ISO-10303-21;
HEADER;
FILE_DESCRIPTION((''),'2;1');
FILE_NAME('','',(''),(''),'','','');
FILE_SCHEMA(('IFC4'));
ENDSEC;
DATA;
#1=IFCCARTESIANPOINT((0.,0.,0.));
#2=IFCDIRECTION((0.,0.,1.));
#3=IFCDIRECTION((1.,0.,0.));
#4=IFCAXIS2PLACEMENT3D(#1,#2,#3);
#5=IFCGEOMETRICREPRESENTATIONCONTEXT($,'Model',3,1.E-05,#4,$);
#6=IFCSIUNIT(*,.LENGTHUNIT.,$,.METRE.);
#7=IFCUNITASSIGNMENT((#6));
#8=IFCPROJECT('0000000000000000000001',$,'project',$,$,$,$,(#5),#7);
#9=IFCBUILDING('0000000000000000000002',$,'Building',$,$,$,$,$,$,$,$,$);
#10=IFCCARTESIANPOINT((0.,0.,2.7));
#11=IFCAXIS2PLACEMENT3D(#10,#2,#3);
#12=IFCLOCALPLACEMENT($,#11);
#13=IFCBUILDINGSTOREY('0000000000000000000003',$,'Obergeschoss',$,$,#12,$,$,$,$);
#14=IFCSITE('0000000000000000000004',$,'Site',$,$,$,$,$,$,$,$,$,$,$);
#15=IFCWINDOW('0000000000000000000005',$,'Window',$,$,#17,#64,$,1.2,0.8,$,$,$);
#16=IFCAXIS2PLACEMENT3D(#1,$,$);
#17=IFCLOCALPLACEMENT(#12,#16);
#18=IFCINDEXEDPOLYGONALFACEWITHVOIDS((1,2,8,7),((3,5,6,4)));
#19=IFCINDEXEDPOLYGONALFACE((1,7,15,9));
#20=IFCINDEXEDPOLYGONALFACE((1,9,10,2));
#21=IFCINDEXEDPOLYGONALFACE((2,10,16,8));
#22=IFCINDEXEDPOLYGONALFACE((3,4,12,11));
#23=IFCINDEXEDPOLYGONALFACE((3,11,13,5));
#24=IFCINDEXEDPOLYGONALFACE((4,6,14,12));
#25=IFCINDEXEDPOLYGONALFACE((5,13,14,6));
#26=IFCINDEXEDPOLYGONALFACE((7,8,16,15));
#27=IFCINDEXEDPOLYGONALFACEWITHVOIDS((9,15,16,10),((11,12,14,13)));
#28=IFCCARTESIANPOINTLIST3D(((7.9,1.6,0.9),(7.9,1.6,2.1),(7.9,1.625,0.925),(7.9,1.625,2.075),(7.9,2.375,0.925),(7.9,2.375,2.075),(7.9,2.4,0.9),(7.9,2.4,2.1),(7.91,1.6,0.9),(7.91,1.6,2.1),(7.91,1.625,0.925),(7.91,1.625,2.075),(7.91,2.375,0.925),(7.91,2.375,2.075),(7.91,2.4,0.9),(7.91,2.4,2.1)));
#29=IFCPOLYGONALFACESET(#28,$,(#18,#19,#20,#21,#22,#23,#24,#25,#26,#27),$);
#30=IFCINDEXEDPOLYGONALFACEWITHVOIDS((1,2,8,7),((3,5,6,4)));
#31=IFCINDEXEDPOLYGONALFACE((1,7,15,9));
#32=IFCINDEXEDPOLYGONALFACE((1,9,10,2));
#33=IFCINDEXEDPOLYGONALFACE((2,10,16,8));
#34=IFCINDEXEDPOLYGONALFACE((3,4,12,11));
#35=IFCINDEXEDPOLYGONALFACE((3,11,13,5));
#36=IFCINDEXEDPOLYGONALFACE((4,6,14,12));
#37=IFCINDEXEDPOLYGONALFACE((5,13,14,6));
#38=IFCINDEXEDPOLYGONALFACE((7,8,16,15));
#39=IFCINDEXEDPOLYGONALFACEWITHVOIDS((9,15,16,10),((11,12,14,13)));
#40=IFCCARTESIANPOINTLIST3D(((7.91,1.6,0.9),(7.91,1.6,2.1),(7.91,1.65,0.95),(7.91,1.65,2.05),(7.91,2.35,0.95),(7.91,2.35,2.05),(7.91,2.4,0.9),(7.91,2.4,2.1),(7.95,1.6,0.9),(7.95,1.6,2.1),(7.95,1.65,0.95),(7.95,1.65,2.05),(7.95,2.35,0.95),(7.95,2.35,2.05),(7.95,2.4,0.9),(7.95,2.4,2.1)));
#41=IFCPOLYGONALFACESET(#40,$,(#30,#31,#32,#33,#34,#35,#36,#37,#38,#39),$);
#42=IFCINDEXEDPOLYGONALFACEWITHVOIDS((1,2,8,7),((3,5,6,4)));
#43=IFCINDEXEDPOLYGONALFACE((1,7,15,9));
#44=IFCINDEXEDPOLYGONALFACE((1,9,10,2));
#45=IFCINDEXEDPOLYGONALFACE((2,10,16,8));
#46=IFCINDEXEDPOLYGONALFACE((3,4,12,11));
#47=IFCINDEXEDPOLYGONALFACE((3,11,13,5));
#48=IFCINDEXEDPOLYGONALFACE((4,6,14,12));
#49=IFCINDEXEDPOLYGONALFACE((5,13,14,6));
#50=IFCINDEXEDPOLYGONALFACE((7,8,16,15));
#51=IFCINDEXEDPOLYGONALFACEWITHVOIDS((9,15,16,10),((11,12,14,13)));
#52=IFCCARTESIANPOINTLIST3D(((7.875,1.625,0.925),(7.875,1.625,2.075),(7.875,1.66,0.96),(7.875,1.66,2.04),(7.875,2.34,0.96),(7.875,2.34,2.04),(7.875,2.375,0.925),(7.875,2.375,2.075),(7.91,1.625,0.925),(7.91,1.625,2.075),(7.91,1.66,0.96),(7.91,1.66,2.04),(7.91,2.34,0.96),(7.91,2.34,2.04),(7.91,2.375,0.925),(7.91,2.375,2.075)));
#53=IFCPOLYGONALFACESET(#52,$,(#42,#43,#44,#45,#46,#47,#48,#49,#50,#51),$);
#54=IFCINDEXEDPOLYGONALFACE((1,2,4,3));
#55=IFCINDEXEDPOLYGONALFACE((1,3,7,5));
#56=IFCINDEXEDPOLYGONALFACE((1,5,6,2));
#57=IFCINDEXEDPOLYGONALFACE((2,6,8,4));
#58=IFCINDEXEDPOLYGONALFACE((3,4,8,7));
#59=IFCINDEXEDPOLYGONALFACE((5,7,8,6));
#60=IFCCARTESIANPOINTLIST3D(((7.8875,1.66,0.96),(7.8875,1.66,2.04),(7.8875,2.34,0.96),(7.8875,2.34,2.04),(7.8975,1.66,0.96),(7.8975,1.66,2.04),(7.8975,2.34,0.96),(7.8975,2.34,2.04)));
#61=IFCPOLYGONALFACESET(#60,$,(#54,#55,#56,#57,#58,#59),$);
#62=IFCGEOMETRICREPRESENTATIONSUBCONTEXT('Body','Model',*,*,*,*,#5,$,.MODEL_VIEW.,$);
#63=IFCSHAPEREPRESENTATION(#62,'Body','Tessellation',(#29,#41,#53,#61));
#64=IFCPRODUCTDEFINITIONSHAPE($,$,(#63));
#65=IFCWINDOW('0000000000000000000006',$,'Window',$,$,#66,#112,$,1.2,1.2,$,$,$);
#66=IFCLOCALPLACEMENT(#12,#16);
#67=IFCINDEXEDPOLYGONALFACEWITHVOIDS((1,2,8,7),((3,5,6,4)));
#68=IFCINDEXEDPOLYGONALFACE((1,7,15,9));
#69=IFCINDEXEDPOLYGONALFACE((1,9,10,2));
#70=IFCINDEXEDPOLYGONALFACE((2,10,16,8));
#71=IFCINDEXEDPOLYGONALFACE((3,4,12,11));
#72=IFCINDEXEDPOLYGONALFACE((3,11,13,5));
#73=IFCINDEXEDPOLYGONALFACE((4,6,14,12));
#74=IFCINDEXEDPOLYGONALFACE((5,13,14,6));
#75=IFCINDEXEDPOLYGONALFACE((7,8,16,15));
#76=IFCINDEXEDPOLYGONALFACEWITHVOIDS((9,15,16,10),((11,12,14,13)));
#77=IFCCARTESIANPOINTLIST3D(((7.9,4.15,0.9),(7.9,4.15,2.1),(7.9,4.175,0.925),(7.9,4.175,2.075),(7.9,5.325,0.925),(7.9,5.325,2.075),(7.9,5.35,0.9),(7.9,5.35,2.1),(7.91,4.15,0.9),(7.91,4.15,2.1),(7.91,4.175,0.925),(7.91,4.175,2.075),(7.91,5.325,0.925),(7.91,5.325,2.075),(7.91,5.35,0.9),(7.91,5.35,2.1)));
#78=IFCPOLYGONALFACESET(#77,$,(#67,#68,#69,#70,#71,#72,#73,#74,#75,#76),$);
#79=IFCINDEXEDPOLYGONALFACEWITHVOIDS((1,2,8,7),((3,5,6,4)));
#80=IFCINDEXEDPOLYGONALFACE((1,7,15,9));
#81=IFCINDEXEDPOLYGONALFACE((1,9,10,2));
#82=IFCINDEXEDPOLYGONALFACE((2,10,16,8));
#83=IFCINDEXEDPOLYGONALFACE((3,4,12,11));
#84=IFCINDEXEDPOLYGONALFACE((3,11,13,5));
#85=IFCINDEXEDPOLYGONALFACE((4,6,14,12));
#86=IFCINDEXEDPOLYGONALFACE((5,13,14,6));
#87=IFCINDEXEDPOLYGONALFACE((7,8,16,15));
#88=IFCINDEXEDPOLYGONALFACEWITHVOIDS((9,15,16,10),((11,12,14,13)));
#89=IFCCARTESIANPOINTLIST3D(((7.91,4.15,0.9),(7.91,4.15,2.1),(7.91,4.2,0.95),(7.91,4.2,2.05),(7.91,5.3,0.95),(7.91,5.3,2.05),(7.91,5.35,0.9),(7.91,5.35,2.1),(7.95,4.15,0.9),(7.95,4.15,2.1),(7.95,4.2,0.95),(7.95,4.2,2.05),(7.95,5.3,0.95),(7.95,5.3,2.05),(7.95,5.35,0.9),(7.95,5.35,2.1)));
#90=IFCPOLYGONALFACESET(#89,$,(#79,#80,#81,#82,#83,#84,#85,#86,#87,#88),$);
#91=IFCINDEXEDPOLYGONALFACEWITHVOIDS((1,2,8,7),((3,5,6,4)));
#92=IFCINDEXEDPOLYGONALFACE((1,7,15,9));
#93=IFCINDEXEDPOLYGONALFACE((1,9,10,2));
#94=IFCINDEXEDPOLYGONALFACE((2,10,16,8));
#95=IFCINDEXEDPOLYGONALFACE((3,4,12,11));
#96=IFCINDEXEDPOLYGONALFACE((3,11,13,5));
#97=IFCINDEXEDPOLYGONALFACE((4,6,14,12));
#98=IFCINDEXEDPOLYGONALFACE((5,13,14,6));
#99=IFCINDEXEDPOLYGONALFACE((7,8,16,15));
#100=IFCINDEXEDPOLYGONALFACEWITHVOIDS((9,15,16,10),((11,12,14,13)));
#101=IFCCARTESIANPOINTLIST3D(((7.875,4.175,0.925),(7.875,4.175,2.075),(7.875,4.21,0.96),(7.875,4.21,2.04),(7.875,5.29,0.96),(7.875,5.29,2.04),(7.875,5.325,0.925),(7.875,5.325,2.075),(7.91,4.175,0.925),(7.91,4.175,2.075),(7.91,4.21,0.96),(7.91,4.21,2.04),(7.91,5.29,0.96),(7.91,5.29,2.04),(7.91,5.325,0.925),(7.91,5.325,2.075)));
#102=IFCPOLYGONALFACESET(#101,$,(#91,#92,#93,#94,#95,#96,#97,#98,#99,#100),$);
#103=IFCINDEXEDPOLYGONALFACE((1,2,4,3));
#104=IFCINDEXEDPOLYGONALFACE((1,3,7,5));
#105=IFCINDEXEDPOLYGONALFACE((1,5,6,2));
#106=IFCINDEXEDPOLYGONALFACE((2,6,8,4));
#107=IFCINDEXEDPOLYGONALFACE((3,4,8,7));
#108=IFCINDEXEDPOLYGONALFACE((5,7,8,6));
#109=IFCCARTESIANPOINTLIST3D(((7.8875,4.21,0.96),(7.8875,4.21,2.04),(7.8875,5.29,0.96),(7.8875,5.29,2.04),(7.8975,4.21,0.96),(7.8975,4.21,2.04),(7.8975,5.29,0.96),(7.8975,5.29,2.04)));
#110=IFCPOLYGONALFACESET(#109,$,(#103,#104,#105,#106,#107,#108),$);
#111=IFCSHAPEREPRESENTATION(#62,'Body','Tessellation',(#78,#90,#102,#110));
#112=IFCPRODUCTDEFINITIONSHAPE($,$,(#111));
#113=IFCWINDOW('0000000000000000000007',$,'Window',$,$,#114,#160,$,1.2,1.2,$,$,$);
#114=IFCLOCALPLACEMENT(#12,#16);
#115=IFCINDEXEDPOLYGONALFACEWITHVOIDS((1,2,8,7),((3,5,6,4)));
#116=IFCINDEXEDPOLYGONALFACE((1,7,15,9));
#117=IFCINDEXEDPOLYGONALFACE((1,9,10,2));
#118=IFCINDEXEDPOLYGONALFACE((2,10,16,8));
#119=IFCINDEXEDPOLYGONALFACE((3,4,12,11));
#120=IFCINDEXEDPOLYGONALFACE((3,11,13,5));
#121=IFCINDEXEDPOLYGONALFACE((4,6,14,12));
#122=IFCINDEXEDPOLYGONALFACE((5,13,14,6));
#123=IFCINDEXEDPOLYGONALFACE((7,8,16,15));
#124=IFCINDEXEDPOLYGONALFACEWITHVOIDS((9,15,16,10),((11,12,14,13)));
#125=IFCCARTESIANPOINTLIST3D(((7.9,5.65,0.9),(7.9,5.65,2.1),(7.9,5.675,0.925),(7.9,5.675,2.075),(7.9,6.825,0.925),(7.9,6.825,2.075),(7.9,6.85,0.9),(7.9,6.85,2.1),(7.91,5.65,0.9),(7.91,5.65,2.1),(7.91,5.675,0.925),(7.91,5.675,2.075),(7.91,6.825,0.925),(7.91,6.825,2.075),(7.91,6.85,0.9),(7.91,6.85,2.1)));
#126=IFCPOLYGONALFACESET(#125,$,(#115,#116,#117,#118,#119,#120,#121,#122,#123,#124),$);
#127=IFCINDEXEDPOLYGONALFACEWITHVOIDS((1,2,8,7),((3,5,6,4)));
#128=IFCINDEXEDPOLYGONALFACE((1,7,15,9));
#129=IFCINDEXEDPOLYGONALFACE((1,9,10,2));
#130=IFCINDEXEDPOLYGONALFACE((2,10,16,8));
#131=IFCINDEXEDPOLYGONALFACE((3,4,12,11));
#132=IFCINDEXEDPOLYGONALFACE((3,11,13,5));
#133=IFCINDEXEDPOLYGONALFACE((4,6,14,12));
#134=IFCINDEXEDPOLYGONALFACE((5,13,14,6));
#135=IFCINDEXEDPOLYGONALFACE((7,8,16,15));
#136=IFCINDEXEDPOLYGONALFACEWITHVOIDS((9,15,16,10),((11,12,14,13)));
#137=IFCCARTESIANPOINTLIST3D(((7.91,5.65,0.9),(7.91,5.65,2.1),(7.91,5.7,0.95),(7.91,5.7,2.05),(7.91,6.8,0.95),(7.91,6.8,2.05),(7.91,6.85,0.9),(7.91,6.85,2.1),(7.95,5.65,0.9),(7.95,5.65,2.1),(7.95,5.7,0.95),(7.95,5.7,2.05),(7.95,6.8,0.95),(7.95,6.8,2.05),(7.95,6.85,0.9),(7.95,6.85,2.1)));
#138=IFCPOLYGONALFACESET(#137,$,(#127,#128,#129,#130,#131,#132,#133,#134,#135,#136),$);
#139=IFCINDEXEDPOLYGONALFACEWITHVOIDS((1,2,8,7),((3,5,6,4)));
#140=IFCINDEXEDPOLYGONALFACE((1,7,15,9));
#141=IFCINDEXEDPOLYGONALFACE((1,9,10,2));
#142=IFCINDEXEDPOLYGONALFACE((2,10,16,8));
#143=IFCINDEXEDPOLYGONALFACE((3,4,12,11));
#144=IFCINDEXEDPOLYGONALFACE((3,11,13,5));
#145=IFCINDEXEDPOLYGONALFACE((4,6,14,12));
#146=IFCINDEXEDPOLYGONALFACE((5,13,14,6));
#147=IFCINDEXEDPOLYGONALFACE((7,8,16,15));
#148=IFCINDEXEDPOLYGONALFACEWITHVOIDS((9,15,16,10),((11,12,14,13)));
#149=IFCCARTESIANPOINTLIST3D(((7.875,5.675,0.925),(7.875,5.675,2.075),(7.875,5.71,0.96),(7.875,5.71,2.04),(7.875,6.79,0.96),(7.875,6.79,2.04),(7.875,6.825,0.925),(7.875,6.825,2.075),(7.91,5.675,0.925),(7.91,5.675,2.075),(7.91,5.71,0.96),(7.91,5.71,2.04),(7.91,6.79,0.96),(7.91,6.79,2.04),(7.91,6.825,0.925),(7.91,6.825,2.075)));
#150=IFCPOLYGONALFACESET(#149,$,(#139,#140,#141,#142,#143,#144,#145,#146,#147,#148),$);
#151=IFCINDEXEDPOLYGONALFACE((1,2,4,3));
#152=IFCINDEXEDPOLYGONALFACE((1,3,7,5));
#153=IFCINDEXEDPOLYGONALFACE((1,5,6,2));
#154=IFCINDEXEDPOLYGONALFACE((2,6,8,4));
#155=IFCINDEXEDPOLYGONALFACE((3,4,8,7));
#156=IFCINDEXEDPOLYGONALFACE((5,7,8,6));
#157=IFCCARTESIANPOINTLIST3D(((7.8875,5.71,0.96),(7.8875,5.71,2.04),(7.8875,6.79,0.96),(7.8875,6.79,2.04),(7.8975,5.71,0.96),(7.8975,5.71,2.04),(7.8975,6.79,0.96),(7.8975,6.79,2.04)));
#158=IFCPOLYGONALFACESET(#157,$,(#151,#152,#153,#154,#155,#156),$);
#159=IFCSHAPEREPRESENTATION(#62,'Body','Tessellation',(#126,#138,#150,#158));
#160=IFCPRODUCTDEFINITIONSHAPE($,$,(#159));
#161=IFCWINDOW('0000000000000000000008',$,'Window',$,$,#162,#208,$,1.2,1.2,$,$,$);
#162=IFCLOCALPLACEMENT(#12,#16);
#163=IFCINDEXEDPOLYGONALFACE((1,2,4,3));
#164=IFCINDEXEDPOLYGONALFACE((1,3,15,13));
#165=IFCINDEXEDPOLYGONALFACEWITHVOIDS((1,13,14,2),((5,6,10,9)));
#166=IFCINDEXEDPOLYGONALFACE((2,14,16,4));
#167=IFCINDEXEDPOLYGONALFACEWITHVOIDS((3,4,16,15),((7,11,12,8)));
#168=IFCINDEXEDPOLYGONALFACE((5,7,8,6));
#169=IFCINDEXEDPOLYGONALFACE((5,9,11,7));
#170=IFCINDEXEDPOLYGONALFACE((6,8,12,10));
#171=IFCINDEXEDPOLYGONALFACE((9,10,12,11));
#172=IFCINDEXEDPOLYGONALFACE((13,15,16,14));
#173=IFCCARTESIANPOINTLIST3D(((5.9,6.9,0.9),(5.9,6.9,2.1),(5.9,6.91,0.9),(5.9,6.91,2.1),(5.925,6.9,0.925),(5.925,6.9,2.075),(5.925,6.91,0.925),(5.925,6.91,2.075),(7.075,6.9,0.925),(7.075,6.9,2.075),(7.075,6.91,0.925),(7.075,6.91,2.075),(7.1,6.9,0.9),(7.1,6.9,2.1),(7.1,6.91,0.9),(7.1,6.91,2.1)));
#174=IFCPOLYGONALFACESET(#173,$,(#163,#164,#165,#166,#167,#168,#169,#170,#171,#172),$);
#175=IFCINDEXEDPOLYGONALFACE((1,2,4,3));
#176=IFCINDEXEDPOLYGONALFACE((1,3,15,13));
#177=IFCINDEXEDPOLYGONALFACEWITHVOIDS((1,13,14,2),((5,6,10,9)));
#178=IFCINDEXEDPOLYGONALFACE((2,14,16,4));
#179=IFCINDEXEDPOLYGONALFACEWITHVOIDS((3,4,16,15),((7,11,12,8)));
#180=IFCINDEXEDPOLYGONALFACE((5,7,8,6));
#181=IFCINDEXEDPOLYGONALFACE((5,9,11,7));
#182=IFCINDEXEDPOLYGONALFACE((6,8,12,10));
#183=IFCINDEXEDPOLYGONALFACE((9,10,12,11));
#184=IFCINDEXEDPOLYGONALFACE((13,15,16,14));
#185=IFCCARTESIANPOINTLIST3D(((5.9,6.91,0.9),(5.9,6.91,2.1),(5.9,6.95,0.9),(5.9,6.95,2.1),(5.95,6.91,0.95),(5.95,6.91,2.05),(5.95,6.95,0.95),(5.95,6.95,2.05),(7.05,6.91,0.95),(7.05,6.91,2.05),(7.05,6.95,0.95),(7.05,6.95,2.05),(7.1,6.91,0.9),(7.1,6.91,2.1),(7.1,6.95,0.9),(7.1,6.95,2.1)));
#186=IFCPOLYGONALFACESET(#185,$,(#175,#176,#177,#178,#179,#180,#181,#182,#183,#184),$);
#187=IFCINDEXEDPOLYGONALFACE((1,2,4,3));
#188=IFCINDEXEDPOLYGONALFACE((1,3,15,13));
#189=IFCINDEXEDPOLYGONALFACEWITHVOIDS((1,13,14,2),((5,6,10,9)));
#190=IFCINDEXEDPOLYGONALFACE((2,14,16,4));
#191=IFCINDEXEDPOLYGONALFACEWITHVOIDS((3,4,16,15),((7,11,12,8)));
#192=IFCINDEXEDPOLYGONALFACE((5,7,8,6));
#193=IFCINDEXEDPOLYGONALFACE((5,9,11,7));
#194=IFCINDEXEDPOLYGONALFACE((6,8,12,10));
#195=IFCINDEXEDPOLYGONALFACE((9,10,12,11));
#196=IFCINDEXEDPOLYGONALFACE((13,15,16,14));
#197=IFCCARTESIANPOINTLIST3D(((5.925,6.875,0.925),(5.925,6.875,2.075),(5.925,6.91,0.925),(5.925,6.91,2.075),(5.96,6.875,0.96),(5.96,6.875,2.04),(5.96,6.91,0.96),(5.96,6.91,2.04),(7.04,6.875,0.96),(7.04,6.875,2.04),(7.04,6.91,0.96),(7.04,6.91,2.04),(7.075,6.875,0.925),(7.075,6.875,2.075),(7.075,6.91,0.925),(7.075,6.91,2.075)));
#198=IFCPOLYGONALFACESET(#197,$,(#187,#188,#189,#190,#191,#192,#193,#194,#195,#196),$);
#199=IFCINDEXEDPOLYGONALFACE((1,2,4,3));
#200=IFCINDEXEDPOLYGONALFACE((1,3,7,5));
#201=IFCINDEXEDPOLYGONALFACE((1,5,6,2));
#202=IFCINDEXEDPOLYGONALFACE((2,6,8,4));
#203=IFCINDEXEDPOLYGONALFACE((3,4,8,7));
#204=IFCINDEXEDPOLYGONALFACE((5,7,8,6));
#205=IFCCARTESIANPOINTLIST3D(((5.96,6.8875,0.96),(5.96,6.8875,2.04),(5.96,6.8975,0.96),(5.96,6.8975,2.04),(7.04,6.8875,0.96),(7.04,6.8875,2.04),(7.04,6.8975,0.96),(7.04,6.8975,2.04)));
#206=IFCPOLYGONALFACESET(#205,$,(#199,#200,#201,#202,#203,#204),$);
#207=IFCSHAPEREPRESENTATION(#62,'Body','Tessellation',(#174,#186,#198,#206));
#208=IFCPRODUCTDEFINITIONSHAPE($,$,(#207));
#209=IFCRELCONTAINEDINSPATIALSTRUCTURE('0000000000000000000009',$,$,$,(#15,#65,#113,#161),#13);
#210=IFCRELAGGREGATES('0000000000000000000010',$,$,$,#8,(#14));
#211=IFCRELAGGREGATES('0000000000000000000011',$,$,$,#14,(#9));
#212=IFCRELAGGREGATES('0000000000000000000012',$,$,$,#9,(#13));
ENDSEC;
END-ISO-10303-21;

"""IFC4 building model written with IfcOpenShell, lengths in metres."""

from ifc_helpers import new_model, si_unit, frame, origin_with_axes, place, context, subcontext, project, spatial, line, indexed_curve, outline, extrude, element, save


model = new_model("IFC4")

# Units and contexts
model_context = context("Model", 3, precision=1e-05, world=origin_with_axes())
body_context = subcontext(model_context, "Body", "Model", "MODEL_VIEW")
ifc_project = project(units=[si_unit("LENGTHUNIT", "METRE")], contexts=[model_context])

# Site, building, storey
site = spatial("IfcSite", under=ifc_project, Name="Site")
building = spatial("IfcBuilding", under=site, Name="Building")
storey_placement = place(None, frame((0.0, 0.0, 2.7), z_axis=(0.0, 0.0, 1.0), x_axis=(1.0, 0.0, 0.0)))
storey = spatial("IfcBuildingStorey", under=building, at=storey_placement, Name="Obergeschoss")

# Windows
window_1_placement = place(storey_placement, frame((8.0, 1.6, 0.9), z_axis=(0.0, 0.0, 1.0), x_axis=(0.0, 1.0, 0.0)))
element("IfcWindow", 1, at=window_1_placement, inside=storey, Name="Window", OverallHeight=1.2, OverallWidth=0.8, context=body_context, shape_type="SweptSolid", body=[
    extrude(outline(indexed_curve([(0.0, 0.0), (0.8, 0.0), (0.8, 1.2), (0.0, 1.2)], segments=[line(1, 2, 3, 4, 1)]), holes=[indexed_curve([(0.025, 0.025), (0.775, 0.025), (0.775, 1.175), (0.025, 1.175)], segments=[line(1, 2, 3, 4, 1)])]), frame((0.0, 0.09, 0.0), z_axis=(0.0, -1.0, 0.0), x_axis=(1.0, 0.0, 0.0)), (0.0, 0.0, -1.0), 0.01),
    extrude(outline(indexed_curve([(0.0, 0.0), (0.8, 0.0), (0.8, 1.2), (0.0, 1.2)], segments=[line(1, 2, 3, 4, 1)]), holes=[indexed_curve([(0.05, 0.05), (0.75, 0.05), (0.75, 1.15), (0.05, 1.15)], segments=[line(1, 2, 3, 4, 1)])]), frame((0.0, 0.05, 0.0), z_axis=(0.0, -1.0, 0.0), x_axis=(1.0, 0.0, 0.0)), (0.0, 0.0, -1.0), 0.04),
    extrude(outline(indexed_curve([(0.0, 0.0), (0.75, 0.0), (0.75, 1.15), (0.0, 1.15)], segments=[line(1, 2, 3, 4, 1)]), holes=[indexed_curve([(0.035, 0.035), (0.715, 0.035), (0.715, 1.115), (0.035, 1.115)], segments=[line(1, 2, 3, 4, 1)])]), frame((0.025, 0.09, 0.025), z_axis=(0.0, -1.0, 0.0), x_axis=(1.0, 0.0, 0.0)), (0.0, 0.0, -1.0), 0.035),
    extrude(outline(indexed_curve([(0.035, 0.035), (0.715, 0.035), (0.715, 1.115), (0.035, 1.115)], segments=[line(1, 2, 3, 4, 1)])), frame((0.025, 0.1025, 0.025), z_axis=(0.0, -1.0, 0.0), x_axis=(1.0, 0.0, 0.0)), (0.0, 0.0, -1.0), 0.01),
])
for number, where, z_axis, x_axis, name in (
    (2, (8.0, 4.15, 0.9), (0.0, 0.0, 1.0), (0.0, 1.0, 0.0), "Window"),
    (3, (8.0, 5.65, 0.9), (0.0, 0.0, 1.0), (0.0, 1.0, 0.0), "Window"),
    (4, (7.1, 7.0, 0.9), (0.0, 0.0, 1.0), (-1.0, 0.0, 0.0), "Window"),
):
    element("IfcWindow", number, at=place(storey_placement, frame(where, z_axis=z_axis, x_axis=x_axis)), inside=storey, Name=name, OverallHeight=1.2, OverallWidth=1.2, context=body_context, shape_type="SweptSolid", body=[
        extrude(outline(indexed_curve([(0.0, 0.0), (1.2, 0.0), (1.2, 1.2), (0.0, 1.2)], segments=[line(1, 2, 3, 4, 1)]), holes=[indexed_curve([(0.025, 0.025), (1.175, 0.025), (1.175, 1.175), (0.025, 1.175)], segments=[line(1, 2, 3, 4, 1)])]), frame((0.0, 0.09, 0.0), z_axis=(0.0, -1.0, 0.0), x_axis=(1.0, 0.0, 0.0)), (0.0, 0.0, -1.0), 0.01),
        extrude(outline(indexed_curve([(0.0, 0.0), (1.2, 0.0), (1.2, 1.2), (0.0, 1.2)], segments=[line(1, 2, 3, 4, 1)]), holes=[indexed_curve([(0.05, 0.05), (1.15, 0.05), (1.15, 1.15), (0.05, 1.15)], segments=[line(1, 2, 3, 4, 1)])]), frame((0.0, 0.05, 0.0), z_axis=(0.0, -1.0, 0.0), x_axis=(1.0, 0.0, 0.0)), (0.0, 0.0, -1.0), 0.04),
        extrude(outline(indexed_curve([(0.0, 0.0), (1.15, 0.0), (1.15, 1.15), (0.0, 1.15)], segments=[line(1, 2, 3, 4, 1)]), holes=[indexed_curve([(0.035, 0.035), (1.115, 0.035), (1.115, 1.115), (0.035, 1.115)], segments=[line(1, 2, 3, 4, 1)])]), frame((0.025, 0.09, 0.025), z_axis=(0.0, -1.0, 0.0), x_axis=(1.0, 0.0, 0.0)), (0.0, 0.0, -1.0), 0.035),
        extrude(outline(indexed_curve([(0.035, 0.035), (1.115, 0.035), (1.115, 1.115), (0.035, 1.115)], segments=[line(1, 2, 3, 4, 1)])), frame((0.025, 0.1025, 0.025), z_axis=(0.0, -1.0, 0.0), x_axis=(1.0, 0.0, 0.0)), (0.0, 0.0, -1.0), 0.01),
    ])

save(model, "model.ifc")
